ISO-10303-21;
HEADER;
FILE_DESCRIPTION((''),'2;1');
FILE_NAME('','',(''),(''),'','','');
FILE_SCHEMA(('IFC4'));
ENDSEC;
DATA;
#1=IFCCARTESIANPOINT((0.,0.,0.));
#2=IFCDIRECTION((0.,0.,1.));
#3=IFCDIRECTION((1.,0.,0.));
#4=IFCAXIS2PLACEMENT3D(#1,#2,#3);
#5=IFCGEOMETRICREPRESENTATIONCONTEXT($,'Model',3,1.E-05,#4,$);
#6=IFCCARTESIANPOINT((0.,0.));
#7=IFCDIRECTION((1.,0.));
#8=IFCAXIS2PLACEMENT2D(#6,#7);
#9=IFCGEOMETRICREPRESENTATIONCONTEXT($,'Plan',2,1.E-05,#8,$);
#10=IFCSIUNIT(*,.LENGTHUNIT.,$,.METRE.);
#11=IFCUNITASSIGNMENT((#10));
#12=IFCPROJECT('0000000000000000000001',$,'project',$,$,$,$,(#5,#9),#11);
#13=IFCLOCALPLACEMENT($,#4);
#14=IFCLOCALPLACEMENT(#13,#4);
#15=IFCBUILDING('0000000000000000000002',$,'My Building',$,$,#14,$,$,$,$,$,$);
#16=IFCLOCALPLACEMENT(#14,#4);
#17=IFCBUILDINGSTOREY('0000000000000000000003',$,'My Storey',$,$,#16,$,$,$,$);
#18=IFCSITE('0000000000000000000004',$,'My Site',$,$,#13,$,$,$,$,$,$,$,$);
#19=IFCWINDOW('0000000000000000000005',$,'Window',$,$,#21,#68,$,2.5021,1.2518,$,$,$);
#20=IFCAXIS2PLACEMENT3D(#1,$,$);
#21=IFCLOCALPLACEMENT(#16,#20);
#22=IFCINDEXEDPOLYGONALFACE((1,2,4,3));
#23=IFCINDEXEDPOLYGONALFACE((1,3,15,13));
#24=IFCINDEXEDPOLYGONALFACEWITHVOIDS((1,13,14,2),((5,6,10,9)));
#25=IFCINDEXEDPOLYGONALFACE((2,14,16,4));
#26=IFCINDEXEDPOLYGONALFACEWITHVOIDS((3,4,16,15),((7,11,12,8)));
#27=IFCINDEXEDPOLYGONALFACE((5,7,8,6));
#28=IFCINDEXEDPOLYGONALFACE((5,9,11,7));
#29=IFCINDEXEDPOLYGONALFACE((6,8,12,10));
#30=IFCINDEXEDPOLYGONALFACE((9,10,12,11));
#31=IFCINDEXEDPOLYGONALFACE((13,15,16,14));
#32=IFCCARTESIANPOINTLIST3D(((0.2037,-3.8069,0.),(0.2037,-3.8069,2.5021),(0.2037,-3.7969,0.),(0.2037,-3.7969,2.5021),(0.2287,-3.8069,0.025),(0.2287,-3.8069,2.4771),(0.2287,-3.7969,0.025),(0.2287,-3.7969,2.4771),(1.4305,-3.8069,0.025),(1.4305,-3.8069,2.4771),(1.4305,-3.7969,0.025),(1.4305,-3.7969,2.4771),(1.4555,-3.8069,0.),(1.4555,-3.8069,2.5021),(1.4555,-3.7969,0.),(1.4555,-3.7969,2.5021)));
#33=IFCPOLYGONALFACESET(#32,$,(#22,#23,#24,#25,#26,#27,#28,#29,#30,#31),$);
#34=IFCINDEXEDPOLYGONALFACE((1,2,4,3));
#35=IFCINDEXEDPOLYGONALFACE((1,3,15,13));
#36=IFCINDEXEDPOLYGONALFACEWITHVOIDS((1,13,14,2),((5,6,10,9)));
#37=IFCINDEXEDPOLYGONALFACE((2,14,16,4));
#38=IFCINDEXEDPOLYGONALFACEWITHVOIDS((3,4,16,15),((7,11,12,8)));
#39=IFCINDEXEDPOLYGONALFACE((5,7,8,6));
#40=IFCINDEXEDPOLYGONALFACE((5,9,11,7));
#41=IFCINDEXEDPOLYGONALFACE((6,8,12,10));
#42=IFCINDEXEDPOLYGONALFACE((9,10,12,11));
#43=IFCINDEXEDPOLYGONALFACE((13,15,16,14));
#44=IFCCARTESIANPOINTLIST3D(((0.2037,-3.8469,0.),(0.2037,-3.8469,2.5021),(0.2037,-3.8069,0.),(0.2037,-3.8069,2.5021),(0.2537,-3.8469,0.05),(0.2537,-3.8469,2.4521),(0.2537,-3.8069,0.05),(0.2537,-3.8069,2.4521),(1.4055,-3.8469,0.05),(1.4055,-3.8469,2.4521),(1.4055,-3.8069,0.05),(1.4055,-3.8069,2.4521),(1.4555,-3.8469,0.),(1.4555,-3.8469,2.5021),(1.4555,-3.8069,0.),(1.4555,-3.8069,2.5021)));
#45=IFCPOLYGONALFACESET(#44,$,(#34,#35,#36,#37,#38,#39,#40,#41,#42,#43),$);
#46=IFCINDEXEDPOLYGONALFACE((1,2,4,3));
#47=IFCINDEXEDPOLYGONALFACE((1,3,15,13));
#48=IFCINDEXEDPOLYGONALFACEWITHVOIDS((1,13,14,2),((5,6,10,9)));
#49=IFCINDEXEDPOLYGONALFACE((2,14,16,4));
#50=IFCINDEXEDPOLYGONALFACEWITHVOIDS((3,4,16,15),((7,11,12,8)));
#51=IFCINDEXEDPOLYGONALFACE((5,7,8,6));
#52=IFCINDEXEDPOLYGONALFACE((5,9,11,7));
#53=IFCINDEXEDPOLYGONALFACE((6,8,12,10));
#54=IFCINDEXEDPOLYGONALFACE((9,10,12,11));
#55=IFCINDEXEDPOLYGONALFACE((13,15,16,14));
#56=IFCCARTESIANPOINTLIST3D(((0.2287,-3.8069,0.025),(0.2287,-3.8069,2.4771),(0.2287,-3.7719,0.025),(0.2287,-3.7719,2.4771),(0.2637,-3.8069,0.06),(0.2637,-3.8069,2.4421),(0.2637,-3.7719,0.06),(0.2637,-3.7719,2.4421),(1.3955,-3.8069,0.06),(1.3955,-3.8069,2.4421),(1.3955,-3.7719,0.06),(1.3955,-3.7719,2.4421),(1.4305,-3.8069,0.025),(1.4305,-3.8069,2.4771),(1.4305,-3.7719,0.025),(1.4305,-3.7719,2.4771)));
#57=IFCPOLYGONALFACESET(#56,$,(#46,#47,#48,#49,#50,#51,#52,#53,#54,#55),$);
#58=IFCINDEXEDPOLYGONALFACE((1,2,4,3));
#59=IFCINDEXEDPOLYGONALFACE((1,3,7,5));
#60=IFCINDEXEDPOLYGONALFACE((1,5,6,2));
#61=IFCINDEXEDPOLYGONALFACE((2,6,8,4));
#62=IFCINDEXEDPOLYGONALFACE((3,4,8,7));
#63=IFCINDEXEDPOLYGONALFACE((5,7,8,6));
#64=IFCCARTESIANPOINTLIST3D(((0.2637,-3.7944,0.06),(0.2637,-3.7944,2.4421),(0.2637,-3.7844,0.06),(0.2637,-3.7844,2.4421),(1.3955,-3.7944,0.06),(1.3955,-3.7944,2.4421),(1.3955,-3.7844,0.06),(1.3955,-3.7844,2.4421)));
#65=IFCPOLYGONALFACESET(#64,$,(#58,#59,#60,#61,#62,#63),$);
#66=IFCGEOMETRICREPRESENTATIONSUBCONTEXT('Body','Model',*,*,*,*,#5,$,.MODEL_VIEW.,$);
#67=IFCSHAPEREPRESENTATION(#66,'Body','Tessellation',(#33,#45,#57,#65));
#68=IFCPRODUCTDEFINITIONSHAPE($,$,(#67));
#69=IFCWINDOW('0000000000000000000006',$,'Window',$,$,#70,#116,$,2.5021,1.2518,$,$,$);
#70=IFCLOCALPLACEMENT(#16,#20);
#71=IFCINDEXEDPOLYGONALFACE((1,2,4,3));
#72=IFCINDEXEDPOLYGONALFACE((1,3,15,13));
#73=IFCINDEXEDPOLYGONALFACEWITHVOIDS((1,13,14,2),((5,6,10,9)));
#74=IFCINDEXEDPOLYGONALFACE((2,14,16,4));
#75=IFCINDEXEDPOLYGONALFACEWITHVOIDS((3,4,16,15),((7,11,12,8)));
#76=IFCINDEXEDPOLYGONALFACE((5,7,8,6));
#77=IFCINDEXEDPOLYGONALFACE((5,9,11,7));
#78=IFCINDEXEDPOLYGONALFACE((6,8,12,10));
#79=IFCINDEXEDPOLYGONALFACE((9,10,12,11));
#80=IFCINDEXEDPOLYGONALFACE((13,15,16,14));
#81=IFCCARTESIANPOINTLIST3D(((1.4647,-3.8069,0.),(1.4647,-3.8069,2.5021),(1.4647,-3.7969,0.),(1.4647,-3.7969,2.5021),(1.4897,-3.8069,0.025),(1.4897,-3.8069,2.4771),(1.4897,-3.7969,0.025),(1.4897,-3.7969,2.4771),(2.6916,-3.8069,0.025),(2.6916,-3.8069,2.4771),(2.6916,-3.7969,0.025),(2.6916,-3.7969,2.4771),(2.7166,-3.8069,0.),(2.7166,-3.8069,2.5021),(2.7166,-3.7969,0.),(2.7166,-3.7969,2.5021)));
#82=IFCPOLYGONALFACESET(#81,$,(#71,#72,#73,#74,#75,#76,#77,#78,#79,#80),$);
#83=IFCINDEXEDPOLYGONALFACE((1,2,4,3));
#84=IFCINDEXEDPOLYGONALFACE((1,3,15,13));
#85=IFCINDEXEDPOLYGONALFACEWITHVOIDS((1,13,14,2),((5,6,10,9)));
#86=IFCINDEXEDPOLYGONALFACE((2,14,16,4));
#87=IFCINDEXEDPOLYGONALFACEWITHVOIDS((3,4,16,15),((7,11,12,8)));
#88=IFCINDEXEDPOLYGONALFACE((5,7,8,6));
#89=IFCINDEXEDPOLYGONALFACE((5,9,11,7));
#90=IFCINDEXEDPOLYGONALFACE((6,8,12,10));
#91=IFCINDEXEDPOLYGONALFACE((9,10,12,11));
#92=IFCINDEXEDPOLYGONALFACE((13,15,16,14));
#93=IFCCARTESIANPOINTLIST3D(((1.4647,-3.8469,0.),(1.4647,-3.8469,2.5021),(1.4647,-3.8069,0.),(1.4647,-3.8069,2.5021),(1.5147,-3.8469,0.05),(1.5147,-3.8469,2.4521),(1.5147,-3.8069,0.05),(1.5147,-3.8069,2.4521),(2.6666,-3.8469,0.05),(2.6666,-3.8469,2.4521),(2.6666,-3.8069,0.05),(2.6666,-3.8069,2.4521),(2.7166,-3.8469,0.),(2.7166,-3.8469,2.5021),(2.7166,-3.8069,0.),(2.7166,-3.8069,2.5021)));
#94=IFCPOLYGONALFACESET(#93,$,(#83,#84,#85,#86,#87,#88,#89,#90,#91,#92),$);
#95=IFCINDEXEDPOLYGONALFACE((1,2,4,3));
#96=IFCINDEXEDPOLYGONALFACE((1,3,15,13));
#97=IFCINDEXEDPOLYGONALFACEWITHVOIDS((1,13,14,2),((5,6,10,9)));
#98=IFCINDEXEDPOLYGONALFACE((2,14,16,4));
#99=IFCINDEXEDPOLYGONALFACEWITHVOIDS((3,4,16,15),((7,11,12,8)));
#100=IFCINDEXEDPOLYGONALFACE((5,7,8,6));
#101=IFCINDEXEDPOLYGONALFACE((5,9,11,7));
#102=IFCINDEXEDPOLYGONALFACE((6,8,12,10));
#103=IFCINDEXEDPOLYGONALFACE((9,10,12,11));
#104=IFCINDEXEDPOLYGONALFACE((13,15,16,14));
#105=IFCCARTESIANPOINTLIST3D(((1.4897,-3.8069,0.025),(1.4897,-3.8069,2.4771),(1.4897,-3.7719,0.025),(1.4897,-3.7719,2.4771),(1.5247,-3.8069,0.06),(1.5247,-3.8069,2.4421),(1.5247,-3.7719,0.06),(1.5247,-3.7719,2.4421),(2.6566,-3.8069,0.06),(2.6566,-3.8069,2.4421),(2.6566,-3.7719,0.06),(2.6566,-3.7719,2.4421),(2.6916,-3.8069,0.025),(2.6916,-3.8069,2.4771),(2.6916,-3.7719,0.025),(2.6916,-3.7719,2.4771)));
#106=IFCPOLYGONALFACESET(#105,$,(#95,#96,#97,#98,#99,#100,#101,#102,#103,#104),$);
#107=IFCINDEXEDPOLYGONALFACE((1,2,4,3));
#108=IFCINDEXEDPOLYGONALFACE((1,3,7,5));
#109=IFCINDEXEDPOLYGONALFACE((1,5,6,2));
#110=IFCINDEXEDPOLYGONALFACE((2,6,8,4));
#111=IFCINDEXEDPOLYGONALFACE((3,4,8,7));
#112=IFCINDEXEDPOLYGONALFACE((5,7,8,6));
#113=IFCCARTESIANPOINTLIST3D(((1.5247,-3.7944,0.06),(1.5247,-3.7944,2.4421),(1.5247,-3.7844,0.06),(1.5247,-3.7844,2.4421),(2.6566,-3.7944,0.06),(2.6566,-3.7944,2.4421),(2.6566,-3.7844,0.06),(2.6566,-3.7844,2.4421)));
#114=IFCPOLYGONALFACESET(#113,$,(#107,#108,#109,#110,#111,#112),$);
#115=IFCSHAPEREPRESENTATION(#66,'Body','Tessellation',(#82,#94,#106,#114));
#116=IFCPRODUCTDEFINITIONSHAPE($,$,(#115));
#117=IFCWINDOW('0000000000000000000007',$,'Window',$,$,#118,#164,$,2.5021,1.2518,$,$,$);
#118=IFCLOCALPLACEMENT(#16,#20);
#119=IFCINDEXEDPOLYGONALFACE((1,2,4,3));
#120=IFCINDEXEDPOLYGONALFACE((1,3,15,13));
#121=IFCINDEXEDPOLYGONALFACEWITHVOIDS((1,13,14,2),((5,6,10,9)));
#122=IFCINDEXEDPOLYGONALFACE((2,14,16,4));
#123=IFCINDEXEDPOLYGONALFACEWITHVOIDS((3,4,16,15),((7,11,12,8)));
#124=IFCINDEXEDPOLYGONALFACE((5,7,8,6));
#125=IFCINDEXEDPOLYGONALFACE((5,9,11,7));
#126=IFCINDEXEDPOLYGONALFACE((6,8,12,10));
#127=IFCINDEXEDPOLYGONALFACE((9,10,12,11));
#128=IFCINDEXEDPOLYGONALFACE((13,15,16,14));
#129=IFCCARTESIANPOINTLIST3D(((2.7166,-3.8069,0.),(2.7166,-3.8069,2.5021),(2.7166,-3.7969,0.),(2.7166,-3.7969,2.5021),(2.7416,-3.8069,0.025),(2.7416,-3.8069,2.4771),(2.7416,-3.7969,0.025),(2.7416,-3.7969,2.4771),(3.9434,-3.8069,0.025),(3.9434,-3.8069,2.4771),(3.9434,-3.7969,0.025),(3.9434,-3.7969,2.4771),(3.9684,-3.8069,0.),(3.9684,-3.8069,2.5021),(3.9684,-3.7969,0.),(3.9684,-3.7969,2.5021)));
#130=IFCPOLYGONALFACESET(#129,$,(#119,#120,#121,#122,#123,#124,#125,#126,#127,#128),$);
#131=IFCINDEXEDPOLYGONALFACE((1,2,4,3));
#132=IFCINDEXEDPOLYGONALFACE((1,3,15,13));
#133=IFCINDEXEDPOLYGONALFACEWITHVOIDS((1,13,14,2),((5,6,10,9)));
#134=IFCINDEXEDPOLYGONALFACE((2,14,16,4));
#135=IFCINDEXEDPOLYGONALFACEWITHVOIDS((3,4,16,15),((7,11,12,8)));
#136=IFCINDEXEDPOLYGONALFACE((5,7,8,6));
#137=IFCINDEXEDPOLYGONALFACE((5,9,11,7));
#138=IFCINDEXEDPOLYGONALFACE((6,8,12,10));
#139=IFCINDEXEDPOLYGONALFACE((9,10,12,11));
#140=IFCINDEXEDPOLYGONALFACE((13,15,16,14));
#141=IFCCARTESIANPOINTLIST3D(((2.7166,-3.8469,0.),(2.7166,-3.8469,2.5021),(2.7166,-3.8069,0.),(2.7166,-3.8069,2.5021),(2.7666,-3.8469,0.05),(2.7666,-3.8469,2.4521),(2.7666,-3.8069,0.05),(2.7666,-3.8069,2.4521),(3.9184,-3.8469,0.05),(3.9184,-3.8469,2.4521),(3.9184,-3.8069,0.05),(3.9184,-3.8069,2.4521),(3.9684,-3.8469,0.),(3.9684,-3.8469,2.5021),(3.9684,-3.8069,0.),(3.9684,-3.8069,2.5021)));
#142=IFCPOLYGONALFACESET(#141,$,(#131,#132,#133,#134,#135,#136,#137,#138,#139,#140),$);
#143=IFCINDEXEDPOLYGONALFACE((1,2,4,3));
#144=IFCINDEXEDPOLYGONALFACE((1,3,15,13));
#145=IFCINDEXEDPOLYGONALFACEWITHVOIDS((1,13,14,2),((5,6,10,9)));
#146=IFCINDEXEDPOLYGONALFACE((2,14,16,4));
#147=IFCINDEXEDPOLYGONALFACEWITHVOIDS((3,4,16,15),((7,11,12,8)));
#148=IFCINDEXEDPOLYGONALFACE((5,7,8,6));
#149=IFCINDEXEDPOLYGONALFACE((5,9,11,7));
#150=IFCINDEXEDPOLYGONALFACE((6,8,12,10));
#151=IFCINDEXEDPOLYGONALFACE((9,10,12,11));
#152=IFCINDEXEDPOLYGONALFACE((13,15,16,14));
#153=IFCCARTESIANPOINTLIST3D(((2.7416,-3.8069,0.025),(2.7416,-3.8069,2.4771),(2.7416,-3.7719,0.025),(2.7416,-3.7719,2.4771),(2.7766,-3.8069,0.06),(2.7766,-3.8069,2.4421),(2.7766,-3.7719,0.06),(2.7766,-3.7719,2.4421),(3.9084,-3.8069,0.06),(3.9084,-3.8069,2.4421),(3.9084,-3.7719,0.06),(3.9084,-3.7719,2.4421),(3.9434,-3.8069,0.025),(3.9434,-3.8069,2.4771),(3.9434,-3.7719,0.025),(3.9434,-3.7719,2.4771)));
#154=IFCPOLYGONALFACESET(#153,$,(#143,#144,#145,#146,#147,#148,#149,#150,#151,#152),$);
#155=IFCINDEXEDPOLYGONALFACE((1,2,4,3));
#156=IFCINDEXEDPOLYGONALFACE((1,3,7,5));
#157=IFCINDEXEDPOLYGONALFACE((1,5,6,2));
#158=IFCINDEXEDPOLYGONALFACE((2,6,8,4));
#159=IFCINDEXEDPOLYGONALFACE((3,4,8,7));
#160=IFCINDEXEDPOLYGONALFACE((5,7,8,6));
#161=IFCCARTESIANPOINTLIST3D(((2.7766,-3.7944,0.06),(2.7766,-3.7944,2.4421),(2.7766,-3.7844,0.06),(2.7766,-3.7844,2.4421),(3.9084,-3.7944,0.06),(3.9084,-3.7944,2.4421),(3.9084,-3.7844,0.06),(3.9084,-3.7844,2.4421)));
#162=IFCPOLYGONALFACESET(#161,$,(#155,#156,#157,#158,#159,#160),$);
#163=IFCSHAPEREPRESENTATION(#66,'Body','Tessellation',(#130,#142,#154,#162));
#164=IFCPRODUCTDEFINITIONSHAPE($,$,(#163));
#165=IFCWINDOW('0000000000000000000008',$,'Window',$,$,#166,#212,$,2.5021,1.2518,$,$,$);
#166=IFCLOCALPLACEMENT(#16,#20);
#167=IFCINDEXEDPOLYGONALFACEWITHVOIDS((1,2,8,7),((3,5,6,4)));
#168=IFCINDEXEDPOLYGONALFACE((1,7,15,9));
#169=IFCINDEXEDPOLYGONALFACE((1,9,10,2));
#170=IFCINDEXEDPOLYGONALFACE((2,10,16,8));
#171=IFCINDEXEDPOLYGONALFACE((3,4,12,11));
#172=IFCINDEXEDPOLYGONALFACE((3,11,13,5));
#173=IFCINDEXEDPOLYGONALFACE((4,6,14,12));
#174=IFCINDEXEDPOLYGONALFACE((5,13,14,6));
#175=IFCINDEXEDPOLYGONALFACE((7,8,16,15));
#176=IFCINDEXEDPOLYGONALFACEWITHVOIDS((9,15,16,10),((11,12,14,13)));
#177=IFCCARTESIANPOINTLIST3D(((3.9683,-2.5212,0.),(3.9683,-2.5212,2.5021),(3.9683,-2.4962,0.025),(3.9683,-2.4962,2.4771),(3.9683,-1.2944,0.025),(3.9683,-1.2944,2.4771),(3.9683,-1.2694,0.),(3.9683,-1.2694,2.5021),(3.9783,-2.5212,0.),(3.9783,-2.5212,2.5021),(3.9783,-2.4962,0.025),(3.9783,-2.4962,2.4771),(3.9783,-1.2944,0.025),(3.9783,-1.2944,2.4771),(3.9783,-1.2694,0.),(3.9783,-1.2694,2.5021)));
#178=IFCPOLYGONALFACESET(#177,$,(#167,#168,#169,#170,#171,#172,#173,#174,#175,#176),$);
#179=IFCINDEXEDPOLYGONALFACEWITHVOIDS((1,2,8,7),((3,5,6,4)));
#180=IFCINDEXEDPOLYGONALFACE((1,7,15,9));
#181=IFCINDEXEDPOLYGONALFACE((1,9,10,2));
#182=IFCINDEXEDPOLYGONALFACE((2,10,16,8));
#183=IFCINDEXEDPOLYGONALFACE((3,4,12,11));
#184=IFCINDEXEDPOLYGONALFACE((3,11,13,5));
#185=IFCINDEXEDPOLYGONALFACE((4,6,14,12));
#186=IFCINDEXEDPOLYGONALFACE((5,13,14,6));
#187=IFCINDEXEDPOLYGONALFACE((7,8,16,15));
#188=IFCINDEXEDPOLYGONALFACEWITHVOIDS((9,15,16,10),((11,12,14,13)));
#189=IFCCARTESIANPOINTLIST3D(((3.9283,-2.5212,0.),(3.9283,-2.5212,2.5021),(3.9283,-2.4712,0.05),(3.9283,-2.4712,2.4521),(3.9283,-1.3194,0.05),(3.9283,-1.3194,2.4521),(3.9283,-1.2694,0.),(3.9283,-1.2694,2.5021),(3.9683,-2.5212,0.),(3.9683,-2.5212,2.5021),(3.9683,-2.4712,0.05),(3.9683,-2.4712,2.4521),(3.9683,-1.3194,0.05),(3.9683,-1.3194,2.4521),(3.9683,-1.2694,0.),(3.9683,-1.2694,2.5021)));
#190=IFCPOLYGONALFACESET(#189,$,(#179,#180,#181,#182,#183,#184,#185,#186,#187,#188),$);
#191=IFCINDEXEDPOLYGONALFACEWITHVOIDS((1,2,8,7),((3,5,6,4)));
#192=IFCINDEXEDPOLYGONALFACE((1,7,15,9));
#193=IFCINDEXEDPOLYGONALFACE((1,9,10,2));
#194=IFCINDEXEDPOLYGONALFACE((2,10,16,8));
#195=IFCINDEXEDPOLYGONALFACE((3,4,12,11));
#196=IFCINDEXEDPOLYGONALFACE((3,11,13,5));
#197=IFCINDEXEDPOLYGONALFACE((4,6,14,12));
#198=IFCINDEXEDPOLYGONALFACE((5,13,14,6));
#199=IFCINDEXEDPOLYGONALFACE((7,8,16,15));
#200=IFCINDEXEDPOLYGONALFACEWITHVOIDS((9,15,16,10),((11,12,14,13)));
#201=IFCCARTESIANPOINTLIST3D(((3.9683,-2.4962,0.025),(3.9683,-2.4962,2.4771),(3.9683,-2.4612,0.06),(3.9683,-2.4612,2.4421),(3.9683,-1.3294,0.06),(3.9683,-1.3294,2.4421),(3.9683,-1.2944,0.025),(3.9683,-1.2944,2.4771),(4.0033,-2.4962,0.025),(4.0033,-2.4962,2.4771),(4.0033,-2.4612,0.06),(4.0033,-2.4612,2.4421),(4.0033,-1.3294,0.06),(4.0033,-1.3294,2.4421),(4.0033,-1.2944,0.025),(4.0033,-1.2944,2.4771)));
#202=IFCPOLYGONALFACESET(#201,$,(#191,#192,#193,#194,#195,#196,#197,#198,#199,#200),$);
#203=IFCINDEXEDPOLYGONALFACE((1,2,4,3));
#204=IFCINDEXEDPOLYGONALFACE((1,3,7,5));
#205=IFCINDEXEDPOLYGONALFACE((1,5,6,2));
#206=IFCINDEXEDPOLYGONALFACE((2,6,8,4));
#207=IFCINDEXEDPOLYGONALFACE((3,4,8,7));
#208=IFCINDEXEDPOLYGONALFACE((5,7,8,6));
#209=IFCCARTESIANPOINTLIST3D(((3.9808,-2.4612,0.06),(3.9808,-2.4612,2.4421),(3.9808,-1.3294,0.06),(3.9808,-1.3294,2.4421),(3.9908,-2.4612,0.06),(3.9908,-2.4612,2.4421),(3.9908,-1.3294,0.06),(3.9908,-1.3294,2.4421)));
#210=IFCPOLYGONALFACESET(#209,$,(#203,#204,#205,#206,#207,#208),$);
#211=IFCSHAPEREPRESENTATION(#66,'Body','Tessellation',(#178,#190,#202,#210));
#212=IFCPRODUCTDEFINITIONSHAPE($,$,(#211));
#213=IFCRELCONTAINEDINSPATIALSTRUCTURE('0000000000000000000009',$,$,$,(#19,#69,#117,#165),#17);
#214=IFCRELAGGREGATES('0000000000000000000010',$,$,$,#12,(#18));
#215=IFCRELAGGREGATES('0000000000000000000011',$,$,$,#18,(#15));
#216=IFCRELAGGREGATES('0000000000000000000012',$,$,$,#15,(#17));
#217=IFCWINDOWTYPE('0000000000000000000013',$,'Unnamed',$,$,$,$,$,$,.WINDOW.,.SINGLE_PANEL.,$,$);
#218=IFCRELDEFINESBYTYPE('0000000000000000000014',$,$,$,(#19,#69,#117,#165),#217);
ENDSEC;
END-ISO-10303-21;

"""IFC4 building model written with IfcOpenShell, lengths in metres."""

from ifc_helpers import new_model, entity, si_unit, frame, origin_with_axes, origin_2d_with_axis, place, context, subcontext, project, spatial, line, indexed_curve, outline, extrude, shape, source, transform, mapped, type_object, type_shapes, element, save


model = new_model("IFC4")

# Units and contexts
model_context = context("Model", 3, precision=1e-05, world=origin_with_axes())
plan_context = context("Plan", 2, precision=1e-05, world=origin_2d_with_axis())
body_context_1 = subcontext(model_context, "Body", "Model", "MODEL_VIEW")
body_context_2 = subcontext(plan_context, "Body", "Plan", "PLAN_VIEW")
ifc_project = project(units=[si_unit("LENGTHUNIT", "METRE")], contexts=[model_context, plan_context])

# Site, building, storey
site_placement = place(None, origin_with_axes())
site = spatial("IfcSite", under=ifc_project, at=site_placement, Name="My Site")
building_placement = place(site_placement, origin_with_axes())
building = spatial("IfcBuilding", under=site, at=building_placement, Name="My Building")
storey_placement = place(building_placement, origin_with_axes())
storey = spatial("IfcBuildingStorey", under=building, at=storey_placement, Name="My Storey")

# Windows
window_type = type_object("IfcWindowType", Name="Unnamed", PartitioningType="SINGLE_PANEL", PredefinedType="WINDOW")
shared_shape_1 = source(origin_with_axes(), body_context_1, "Body", "SweptSolid", [
    extrude(outline(indexed_curve([(0.0, 0.0), (1.2518, 0.0), (1.2518, 2.5021), (0.0, 2.5021)], segments=[line(1, 2, 3, 4, 1)]), holes=[indexed_curve([(0.025, 0.025), (1.2268, 0.025), (1.2268, 2.4771), (0.025, 2.4771)], segments=[line(1, 2, 3, 4, 1)])]), frame((0.0, 0.09, 0.0), z_axis=(0.0, -1.0, 0.0), x_axis=(1.0, 0.0, 0.0)), (0.0, 0.0, -1.0), 0.01),
    extrude(outline(indexed_curve([(0.0, 0.0), (1.2518, 0.0), (1.2518, 2.5021), (0.0, 2.5021)], segments=[line(1, 2, 3, 4, 1)]), holes=[indexed_curve([(0.05, 0.05), (1.2018, 0.05), (1.2018, 2.4521), (0.05, 2.4521)], segments=[line(1, 2, 3, 4, 1)])]), frame((0.0, 0.05, 0.0), z_axis=(0.0, -1.0, 0.0), x_axis=(1.0, 0.0, 0.0)), (0.0, 0.0, -1.0), 0.04),
    extrude(outline(indexed_curve([(0.0, 0.0), (1.2018, 0.0), (1.2018, 2.4521), (0.0, 2.4521)], segments=[line(1, 2, 3, 4, 1)]), holes=[indexed_curve([(0.035, 0.035), (1.1668, 0.035), (1.1668, 2.4171), (0.035, 2.4171)], segments=[line(1, 2, 3, 4, 1)])]), frame((0.025, 0.09, 0.025), z_axis=(0.0, -1.0, 0.0), x_axis=(1.0, 0.0, 0.0)), (0.0, 0.0, -1.0), 0.035),
    extrude(outline(indexed_curve([(0.035, 0.035), (1.1668, 0.035), (1.1668, 2.4171), (0.035, 2.4171)], segments=[line(1, 2, 3, 4, 1)])), frame((0.025, 0.1025, 0.025), z_axis=(0.0, -1.0, 0.0), x_axis=(1.0, 0.0, 0.0)), (0.0, 0.0, -1.0), 0.01),
])
shared_shape_2 = source(origin_with_axes(), body_context_2, "Body", "Curve2D", [
    entity("IfcIndexedPolyCurve", entity("IfcCartesianPointList2D", [[0.05, 0.05], [1.2018, 0.05]])),
    entity("IfcIndexedPolyCurve", entity("IfcCartesianPointList2D", [[0.0, 0.1], [0.025, 0.1], [0.025, 0.09], [0.05, 0.09], [0.05, 0.05], [0.0, 0.05]]), [entity("IfcLineIndex", [1, 2, 3, 4, 5, 6, 1])]),
    entity("IfcIndexedPolyCurve", entity("IfcCartesianPointList2D", [[1.2518, 0.1], [1.2268, 0.1], [1.2268, 0.09], [1.2018, 0.09], [1.2018, 0.05], [1.2518, 0.05]]), [entity("IfcLineIndex", [1, 2, 3, 4, 5, 6, 1])]),
    entity("IfcIndexedPolyCurve", entity("IfcCartesianPointList2D", [[0.025, 0.09], [0.06, 0.09], [0.06, 0.125], [0.025, 0.125]]), [entity("IfcLineIndex", [1, 2, 3, 4, 1])]),
    entity("IfcIndexedPolyCurve", entity("IfcCartesianPointList2D", [[1.2268, 0.09], [1.1918, 0.09], [1.1918, 0.125], [1.2268, 0.125]]), [entity("IfcLineIndex", [1, 2, 3, 4, 1])]),
    entity("IfcIndexedPolyCurve", entity("IfcCartesianPointList2D", [[0.06, 0.09], [1.1918, 0.09]])),
    entity("IfcIndexedPolyCurve", entity("IfcCartesianPointList2D", [[0.06, 0.125], [1.1918, 0.125]])),
    entity("IfcIndexedPolyCurve", entity("IfcCartesianPointList2D", [[0.06, 0.1075], [1.1918, 0.1075]])),
])
type_shapes(window_type, [shared_shape_1, shared_shape_2])
for number, where, z_axis, x_axis, name in (
    (1, (0.2037, -3.8969, 0.0), (0.0, 0.0, 1.0), (1.0, 0.0, 0.0), "Window"),
    (2, (1.4647, -3.8969, 0.0), (0.0, 0.0, 1.0), (1.0, 0.0, 0.0), "Window"),
    (3, (2.7166, -3.8969, 0.0), (0.0, 0.0, 1.0), (1.0, 0.0, 0.0), "Window"),
    (4, (3.8783, -1.2694, 0.0), (0.0, 0.0, 1.0), (0.0, -1.0, 0.0), "Window"),
):
    element("IfcWindow", number, at=place(storey_placement, frame(where, z_axis=z_axis, x_axis=x_axis)), inside=storey, type_object=window_type, Name=name, OverallHeight=2.5021, OverallWidth=1.2518, shapes=[
        shape(body_context_1, "Body", "MappedRepresentation", [mapped(shared_shape_1, transform((0.0, 0.0, 0.0), x_axis=(1.0, 0.0, 0.0), y_axis=(0.0, 1.0, 0.0), z_axis=(0.0, 0.0, 1.0), scale=1.0))]),
        shape(body_context_2, "Body", "MappedRepresentation", [mapped(shared_shape_2, transform((0.0, 0.0, 0.0), x_axis=(1.0, 0.0, 0.0), y_axis=(0.0, 1.0, 0.0), z_axis=(0.0, 0.0, 1.0), scale=1.0))]),
    ])

save(model, "model.ifc")
